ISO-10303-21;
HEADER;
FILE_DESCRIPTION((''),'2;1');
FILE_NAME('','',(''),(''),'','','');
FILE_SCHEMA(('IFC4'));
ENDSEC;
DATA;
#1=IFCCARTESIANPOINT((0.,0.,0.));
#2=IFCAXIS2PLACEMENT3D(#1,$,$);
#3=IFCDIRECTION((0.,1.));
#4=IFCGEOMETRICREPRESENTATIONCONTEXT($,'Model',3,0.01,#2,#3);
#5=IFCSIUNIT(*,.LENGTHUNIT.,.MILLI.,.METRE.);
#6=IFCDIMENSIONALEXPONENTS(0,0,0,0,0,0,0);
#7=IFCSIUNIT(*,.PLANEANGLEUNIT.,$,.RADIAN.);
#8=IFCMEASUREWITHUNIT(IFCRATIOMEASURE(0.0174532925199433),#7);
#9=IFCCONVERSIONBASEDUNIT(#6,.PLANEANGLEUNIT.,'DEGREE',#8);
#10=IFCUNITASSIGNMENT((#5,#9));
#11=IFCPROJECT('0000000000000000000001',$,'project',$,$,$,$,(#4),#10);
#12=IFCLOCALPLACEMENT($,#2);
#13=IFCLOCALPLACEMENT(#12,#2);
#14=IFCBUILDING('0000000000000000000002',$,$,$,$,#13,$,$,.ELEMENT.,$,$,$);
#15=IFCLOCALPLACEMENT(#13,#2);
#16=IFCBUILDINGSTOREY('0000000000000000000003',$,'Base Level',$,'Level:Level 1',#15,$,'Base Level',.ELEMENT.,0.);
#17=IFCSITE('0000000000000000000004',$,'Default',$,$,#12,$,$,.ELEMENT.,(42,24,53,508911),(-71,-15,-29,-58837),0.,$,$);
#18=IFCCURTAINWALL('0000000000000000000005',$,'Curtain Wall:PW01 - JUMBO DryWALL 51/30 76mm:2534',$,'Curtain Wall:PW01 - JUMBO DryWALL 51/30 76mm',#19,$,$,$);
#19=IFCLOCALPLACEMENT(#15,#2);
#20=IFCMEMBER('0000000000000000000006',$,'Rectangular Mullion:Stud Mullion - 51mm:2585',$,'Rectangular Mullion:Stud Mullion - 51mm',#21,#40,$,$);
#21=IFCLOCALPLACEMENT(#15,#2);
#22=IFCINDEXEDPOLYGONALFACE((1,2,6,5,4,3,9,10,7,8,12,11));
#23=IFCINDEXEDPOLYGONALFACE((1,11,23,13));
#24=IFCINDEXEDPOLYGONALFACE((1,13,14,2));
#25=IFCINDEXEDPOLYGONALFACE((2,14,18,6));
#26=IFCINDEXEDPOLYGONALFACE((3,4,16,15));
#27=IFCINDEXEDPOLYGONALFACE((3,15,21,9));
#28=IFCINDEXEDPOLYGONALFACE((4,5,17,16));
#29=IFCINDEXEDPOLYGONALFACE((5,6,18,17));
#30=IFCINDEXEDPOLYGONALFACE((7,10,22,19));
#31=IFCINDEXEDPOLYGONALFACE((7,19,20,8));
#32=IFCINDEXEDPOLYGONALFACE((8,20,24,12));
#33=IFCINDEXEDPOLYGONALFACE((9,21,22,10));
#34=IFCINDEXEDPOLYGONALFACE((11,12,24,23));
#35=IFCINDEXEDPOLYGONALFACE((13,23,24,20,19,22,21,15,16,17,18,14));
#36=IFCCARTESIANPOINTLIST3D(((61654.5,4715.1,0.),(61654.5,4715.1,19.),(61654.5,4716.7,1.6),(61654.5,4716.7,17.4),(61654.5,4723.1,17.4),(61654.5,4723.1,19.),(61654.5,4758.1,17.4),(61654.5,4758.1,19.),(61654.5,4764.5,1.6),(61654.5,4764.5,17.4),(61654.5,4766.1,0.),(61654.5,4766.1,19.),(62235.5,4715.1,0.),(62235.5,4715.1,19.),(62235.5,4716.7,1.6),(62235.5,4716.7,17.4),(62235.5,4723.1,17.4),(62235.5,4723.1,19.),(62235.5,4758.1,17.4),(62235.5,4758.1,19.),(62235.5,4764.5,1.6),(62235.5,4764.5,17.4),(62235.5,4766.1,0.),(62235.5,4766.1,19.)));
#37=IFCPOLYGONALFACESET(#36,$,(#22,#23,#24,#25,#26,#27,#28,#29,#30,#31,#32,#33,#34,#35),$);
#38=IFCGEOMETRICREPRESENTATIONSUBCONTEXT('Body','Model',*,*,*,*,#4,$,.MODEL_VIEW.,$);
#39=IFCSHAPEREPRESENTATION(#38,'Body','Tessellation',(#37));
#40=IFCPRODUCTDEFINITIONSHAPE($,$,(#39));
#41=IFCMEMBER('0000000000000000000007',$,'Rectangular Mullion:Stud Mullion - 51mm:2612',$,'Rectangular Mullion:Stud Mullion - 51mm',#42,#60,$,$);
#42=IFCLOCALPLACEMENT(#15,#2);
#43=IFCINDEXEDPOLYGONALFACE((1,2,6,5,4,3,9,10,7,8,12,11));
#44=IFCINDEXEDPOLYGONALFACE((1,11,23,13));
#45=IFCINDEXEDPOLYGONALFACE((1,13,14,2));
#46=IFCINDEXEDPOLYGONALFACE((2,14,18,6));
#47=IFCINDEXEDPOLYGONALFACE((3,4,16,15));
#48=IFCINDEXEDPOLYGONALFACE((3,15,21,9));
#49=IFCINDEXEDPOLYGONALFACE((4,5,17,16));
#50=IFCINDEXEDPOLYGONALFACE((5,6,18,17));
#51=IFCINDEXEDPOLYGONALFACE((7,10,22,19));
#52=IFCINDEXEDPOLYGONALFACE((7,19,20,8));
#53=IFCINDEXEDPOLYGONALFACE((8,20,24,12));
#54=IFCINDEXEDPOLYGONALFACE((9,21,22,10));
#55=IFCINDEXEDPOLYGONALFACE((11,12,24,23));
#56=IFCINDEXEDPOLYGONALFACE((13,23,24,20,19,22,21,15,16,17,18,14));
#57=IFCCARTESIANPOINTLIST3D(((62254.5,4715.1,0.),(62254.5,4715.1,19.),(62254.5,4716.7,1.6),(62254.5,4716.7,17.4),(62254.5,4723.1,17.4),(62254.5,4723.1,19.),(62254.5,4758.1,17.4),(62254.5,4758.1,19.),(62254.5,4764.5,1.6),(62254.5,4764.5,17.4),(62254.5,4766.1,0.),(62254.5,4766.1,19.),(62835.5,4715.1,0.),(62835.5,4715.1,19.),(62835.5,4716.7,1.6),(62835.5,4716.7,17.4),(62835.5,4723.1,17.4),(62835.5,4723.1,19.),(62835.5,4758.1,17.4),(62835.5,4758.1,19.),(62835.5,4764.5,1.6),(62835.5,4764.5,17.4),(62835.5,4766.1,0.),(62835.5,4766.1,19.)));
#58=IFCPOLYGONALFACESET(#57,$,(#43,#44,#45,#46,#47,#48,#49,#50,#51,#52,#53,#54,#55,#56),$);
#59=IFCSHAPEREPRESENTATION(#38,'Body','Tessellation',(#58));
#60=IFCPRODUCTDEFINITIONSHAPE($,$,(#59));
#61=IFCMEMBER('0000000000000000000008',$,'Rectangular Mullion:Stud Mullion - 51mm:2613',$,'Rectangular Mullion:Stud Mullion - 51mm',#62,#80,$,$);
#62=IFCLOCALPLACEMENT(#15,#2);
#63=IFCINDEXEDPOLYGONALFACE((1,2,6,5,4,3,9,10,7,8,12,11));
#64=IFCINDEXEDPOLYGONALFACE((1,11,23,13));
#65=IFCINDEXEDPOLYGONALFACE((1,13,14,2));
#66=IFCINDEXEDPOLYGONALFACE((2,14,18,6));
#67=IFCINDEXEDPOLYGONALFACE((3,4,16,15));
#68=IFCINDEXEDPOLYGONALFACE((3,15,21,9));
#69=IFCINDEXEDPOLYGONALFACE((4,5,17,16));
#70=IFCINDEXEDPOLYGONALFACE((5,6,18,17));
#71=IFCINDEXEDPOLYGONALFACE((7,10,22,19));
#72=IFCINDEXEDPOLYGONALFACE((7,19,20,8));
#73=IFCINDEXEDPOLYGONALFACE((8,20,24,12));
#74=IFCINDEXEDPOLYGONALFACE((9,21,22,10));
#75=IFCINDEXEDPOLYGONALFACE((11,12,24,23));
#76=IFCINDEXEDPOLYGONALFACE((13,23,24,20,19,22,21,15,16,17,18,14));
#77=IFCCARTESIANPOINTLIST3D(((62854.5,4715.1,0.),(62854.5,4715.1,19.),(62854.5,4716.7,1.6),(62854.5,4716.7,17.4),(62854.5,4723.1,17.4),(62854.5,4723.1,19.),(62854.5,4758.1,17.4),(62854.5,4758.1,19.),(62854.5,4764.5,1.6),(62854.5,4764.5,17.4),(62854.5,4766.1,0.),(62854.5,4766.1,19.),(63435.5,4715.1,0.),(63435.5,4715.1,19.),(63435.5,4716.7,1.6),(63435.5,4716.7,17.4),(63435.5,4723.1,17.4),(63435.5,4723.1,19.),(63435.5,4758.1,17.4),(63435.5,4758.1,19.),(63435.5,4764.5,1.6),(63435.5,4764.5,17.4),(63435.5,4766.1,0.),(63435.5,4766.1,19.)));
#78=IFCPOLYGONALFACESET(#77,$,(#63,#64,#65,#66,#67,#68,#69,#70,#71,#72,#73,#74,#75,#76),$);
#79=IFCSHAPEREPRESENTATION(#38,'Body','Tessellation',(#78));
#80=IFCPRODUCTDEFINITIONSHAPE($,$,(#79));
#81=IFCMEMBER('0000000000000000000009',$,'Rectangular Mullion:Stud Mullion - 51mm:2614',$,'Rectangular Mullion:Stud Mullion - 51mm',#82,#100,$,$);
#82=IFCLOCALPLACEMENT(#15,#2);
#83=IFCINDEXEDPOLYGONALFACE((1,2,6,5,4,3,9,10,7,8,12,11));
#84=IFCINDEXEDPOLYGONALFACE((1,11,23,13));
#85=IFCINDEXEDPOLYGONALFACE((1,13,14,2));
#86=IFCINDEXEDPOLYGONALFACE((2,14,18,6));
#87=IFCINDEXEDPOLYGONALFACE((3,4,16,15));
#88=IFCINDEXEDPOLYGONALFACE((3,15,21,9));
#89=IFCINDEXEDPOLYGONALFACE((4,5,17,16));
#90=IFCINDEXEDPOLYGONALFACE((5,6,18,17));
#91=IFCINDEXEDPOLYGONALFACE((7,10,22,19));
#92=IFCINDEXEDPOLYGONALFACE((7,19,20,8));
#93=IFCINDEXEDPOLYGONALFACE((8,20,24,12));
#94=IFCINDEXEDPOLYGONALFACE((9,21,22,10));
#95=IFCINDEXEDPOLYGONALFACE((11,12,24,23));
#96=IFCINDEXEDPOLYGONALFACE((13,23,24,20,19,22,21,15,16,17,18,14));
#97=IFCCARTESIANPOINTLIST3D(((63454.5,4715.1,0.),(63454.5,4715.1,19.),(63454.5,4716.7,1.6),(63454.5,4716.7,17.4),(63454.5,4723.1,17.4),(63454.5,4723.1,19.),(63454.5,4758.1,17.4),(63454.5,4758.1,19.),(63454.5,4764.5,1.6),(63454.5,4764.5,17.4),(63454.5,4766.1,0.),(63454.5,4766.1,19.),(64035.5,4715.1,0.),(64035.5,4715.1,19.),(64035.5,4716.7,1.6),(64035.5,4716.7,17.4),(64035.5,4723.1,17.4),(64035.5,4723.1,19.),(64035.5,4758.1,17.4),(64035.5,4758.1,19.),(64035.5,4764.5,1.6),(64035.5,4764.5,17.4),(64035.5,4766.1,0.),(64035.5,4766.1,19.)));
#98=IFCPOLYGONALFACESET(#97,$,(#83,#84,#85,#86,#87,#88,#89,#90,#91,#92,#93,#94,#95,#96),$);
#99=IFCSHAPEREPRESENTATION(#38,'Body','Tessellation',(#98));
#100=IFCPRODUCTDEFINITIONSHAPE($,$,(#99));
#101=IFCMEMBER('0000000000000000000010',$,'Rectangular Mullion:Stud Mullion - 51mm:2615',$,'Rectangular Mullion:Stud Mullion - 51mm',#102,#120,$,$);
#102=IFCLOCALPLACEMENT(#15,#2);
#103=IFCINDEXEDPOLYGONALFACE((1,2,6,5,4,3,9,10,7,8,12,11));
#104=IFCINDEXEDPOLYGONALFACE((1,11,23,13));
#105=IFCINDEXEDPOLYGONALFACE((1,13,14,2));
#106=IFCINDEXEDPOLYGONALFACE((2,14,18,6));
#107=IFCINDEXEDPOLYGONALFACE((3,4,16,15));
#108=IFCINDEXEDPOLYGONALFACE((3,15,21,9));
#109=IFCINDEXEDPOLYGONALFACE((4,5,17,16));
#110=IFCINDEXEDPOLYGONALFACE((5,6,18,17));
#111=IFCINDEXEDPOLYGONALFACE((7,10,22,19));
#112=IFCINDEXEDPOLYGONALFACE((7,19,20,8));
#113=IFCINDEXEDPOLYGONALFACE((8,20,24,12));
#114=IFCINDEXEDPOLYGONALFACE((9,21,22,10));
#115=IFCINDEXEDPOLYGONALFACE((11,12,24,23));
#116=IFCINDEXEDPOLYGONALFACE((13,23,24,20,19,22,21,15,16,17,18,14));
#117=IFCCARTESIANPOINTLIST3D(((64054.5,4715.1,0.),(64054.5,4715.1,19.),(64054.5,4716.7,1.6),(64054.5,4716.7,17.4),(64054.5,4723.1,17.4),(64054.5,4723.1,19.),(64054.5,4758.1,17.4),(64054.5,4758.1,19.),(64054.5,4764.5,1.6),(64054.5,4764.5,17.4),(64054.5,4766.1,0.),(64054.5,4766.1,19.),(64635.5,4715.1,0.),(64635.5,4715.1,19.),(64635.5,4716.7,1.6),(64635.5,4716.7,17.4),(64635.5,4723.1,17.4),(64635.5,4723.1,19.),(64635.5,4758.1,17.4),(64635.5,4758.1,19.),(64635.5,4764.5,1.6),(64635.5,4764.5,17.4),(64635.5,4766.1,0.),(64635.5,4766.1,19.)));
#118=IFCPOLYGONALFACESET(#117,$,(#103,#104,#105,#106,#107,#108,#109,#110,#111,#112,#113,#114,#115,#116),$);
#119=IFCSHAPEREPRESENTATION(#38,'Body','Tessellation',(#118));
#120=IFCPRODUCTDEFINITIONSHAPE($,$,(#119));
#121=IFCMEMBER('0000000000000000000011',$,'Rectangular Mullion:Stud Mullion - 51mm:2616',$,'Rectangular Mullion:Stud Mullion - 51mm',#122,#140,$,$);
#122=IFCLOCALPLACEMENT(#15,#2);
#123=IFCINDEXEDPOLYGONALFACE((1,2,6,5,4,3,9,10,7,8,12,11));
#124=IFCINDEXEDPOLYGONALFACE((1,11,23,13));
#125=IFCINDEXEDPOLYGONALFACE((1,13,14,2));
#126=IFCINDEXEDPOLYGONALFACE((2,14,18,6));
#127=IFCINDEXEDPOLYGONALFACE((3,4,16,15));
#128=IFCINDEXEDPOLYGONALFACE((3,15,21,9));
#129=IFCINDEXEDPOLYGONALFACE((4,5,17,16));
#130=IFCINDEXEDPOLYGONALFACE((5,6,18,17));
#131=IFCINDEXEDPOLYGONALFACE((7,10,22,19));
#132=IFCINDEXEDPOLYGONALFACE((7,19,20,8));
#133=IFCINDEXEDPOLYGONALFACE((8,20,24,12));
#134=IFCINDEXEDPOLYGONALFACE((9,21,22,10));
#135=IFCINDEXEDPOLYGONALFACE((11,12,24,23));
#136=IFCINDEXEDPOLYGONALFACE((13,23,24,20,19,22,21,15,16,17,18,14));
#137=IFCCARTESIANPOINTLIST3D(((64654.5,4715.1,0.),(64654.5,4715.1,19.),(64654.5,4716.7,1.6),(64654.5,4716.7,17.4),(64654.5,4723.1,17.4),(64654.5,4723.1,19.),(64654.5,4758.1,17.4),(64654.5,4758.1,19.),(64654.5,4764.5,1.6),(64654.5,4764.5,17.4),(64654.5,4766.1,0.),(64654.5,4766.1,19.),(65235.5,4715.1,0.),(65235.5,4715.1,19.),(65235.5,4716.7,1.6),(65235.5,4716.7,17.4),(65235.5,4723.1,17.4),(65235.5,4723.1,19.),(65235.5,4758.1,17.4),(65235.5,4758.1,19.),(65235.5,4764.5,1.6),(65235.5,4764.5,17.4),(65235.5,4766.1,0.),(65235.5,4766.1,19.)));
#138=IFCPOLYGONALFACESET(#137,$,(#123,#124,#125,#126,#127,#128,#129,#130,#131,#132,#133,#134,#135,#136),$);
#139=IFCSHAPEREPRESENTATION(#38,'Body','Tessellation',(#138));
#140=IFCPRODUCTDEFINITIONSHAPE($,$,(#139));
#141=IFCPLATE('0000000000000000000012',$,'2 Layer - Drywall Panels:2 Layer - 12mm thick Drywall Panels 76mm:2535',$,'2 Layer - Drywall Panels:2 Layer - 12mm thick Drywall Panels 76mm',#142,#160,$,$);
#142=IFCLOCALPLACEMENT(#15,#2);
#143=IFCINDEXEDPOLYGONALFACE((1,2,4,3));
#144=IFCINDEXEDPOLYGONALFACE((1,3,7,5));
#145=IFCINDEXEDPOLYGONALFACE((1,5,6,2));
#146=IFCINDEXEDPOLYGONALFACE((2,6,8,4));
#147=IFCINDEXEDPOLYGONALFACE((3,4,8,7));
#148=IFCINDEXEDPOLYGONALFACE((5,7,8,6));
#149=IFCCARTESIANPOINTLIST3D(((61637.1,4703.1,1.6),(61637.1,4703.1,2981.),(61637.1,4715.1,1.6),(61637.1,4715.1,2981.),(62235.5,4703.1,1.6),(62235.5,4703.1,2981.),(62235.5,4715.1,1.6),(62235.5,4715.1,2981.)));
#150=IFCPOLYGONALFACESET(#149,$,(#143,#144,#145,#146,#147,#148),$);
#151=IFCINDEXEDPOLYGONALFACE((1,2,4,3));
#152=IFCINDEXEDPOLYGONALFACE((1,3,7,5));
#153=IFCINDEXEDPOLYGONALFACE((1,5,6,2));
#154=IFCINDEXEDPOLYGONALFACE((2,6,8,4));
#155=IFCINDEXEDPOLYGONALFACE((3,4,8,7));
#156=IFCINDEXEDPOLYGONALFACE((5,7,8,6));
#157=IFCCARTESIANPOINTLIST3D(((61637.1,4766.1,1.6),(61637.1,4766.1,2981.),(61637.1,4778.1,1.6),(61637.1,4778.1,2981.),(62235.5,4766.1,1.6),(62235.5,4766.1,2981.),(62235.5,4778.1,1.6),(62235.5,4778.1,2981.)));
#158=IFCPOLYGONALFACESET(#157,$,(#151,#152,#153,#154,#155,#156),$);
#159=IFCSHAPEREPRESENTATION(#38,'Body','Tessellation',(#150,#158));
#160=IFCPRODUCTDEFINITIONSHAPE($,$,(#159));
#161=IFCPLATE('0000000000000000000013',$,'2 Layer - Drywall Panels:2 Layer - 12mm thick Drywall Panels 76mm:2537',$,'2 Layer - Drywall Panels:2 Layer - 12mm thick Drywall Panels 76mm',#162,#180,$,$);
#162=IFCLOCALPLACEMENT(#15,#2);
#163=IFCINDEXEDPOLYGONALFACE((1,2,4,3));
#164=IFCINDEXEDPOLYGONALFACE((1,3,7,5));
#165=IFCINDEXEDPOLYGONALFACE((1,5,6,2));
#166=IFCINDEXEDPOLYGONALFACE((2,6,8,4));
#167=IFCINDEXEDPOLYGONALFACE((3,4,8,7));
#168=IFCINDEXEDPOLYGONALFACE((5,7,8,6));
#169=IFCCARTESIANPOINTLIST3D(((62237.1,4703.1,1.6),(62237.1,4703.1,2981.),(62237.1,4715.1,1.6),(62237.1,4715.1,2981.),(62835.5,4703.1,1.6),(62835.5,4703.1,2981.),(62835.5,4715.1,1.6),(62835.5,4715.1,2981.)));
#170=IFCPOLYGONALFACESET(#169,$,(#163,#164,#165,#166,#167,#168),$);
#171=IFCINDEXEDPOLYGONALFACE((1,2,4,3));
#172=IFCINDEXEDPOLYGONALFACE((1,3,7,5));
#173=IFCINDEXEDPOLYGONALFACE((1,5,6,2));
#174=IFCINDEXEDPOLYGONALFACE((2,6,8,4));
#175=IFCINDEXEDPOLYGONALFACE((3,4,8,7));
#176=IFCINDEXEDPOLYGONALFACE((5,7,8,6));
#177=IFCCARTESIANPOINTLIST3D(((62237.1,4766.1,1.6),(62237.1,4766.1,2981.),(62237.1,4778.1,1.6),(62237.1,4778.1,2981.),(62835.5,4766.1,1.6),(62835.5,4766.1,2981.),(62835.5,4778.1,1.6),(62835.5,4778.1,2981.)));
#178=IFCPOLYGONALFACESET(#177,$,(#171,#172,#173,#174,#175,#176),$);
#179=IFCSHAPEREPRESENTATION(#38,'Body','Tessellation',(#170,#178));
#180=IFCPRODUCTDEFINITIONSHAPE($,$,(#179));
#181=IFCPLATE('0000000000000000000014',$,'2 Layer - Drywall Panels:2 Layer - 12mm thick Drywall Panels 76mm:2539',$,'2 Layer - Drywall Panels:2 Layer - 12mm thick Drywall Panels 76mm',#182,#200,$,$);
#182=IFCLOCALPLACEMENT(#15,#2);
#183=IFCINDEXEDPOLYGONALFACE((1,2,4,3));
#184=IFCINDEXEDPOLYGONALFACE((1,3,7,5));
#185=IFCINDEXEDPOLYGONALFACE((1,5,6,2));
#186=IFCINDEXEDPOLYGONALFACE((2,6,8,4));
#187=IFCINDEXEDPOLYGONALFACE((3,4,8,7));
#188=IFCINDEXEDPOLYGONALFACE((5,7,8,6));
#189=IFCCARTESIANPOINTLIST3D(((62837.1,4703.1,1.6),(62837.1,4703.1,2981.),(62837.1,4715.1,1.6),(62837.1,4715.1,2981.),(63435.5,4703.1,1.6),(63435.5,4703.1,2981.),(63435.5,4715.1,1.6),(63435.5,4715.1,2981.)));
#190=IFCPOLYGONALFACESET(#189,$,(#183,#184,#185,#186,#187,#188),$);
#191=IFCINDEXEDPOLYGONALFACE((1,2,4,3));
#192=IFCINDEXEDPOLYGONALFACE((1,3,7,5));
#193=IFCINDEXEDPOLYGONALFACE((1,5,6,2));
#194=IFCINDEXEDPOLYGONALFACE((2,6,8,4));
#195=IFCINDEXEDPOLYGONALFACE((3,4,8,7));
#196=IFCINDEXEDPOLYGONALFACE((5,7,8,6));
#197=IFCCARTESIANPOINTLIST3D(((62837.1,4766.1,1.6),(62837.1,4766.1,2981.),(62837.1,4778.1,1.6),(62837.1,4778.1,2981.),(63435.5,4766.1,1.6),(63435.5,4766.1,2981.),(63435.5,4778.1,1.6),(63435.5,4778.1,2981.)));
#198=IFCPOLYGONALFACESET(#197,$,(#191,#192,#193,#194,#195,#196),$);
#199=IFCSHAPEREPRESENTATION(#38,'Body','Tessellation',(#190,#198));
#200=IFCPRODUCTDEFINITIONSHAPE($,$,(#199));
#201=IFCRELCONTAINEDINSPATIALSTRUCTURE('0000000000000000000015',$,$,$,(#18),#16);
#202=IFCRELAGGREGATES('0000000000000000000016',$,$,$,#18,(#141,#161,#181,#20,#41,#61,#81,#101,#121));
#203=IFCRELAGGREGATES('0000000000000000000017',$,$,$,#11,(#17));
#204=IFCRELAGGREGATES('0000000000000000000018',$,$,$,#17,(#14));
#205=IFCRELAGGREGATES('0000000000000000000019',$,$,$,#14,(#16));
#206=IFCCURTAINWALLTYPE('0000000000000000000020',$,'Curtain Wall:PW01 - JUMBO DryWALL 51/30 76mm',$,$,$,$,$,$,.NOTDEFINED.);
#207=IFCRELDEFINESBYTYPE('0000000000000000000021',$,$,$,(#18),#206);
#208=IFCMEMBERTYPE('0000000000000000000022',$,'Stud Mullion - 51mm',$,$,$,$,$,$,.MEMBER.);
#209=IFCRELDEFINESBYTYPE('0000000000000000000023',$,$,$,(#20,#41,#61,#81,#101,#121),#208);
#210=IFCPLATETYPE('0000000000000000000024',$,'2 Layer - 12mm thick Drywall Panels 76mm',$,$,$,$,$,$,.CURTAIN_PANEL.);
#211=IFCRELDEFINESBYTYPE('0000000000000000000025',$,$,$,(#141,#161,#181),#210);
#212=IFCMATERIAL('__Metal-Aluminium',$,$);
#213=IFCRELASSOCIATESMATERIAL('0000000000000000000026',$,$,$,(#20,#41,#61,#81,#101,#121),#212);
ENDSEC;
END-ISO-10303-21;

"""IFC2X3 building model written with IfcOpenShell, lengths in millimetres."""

from ifc_helpers import new_model, entity, si_unit, converted_unit, direction, frame, frame_2d, origin, origin_2d_with_axis, place, context, subcontext, project, spatial, polyline, rectangle, outline, extrude, source, transform, mapped, material, type_object, type_shapes, element, aggregate, save


model = new_model("IFC2X3")

# Units and contexts
model_context = context("Model", 3, precision=0.01, world=origin(), true_north=direction((0.0, 1.0)))
body_context = subcontext(model_context, "Body", "Model", "MODEL_VIEW")
ifc_project = project(units=[si_unit("LENGTHUNIT", "METRE", prefix="MILLI"), converted_unit("PLANEANGLEUNIT", "DEGREE", entity("IfcRatioMeasure", 0.0174532925199433), si_unit("PLANEANGLEUNIT", "RADIAN"), dimensions=[0, 0, 0, 0, 0, 0, 0])], contexts=[model_context])

# Site, building, storey
site_placement = place(None, origin())
site = spatial("IfcSite", under=ifc_project, at=site_placement, Name="Default", CompositionType="ELEMENT", RefLatitude=(42, 24, 53, 508911), RefLongitude=(-71, -15, -29, -58837), RefElevation=0.0)
building_placement = place(site_placement, origin())
building = spatial("IfcBuilding", under=site, at=building_placement, CompositionType="ELEMENT")
storey_placement = place(building_placement, origin())
storey = spatial("IfcBuildingStorey", under=building, at=storey_placement, Name="Base Level", ObjectType="Level:Level 1", LongName="Base Level", CompositionType="ELEMENT", Elevation=0.0)

# Curtain wall, members, plates
curtain_wall_type = type_object("IfcCurtainWallType", Name="Curtain Wall:PW01 - JUMBO DryWALL 51/30 76mm", PredefinedType="NOTDEFINED")
curtain_wall_placement = place(building_placement, origin())
curtain_wall = element("IfcCurtainWall", 1, at=curtain_wall_placement, inside=storey, type_object=curtain_wall_type, Name="Curtain Wall:PW01 - JUMBO DryWALL 51/30 76mm:2534", ObjectType="Curtain Wall:PW01 - JUMBO DryWALL 51/30 76mm")
ifc_material_1 = material(Name="__Metal-Aluminium")
member_type_1 = type_object("IfcMemberType", Name="Stud Mullion - 51mm", PredefinedType="MEMBER")
shared_shape_1 = source(origin(), body_context, "Body", "SweptSolid", [
    extrude(outline(polyline([(17.5, -6.6), (25.5, -6.6), (25.5, 12.4), (-25.5, 12.4), (-25.5, -6.6), (-17.5, -6.6), (-17.5, -5.0), (-23.9, -5.0), (-23.9, 10.8), (23.9, 10.8), (23.9, -5.0), (17.5, -5.0), (17.5, -6.6)])), frame((-12.4, 0.0, -581.0), z_axis=(0.0, 0.0, 1.0), x_axis=(0.0, -1.0, 0.0)), (0.0, 0.0, 1.0), 581.0),
])
type_shapes(member_type_1, [shared_shape_1])
member_1_placement = place(building_placement, frame((61654.5, 4740.6, 0.0), z_axis=(-1.0, 0.0, 0.0), x_axis=(0.0, 0.0, -1.0)))
member_1 = element("IfcMember", 2, at=member_1_placement, type_object=member_type_1, material=ifc_material_1, Name="Rectangular Mullion:Stud Mullion - 51mm:2585", ObjectType="Rectangular Mullion:Stud Mullion - 51mm", context=body_context, shape_type="MappedRepresentation", body=[
    mapped(shared_shape_1, transform((0.0, 0.0, 0.0), scale=1.0)),
])
member_2_placement = place(building_placement, frame((62254.5, 4740.6, 0.0), z_axis=(-1.0, 0.0, 0.0), x_axis=(0.0, 0.0, -1.0)))
member_2 = element("IfcMember", 3, at=member_2_placement, type_object=member_type_1, material=ifc_material_1, Name="Rectangular Mullion:Stud Mullion - 51mm:2612", ObjectType="Rectangular Mullion:Stud Mullion - 51mm", context=body_context, shape_type="MappedRepresentation", body=[
    mapped(shared_shape_1, transform((0.0, 0.0, 0.0), scale=1.0)),
])
member_3_placement = place(building_placement, frame((62854.5, 4740.6, 0.0), z_axis=(-1.0, 0.0, 0.0), x_axis=(0.0, 0.0, -1.0)))
member_3 = element("IfcMember", 4, at=member_3_placement, type_object=member_type_1, material=ifc_material_1, Name="Rectangular Mullion:Stud Mullion - 51mm:2613", ObjectType="Rectangular Mullion:Stud Mullion - 51mm", context=body_context, shape_type="MappedRepresentation", body=[
    mapped(shared_shape_1, transform((0.0, 0.0, 0.0), scale=1.0)),
])
member_4_placement = place(building_placement, frame((63454.5, 4740.6, 0.0), z_axis=(-1.0, 0.0, 0.0), x_axis=(0.0, 0.0, -1.0)))
member_4 = element("IfcMember", 5, at=member_4_placement, type_object=member_type_1, material=ifc_material_1, Name="Rectangular Mullion:Stud Mullion - 51mm:2614", ObjectType="Rectangular Mullion:Stud Mullion - 51mm", context=body_context, shape_type="MappedRepresentation", body=[
    mapped(shared_shape_1, transform((0.0, 0.0, 0.0), scale=1.0)),
])
member_5_placement = place(building_placement, frame((64054.5, 4740.6, 0.0), z_axis=(-1.0, 0.0, 0.0), x_axis=(0.0, 0.0, -1.0)))
member_5 = element("IfcMember", 6, at=member_5_placement, type_object=member_type_1, material=ifc_material_1, Name="Rectangular Mullion:Stud Mullion - 51mm:2615", ObjectType="Rectangular Mullion:Stud Mullion - 51mm", context=body_context, shape_type="MappedRepresentation", body=[
    mapped(shared_shape_1, transform((0.0, 0.0, 0.0), scale=1.0)),
])
member_6_placement = place(building_placement, frame((64654.5, 4740.6, 0.0), z_axis=(-1.0, 0.0, 0.0), x_axis=(0.0, 0.0, -1.0)))
member_6 = element("IfcMember", 7, at=member_6_placement, type_object=member_type_1, material=ifc_material_1, Name="Rectangular Mullion:Stud Mullion - 51mm:2616", ObjectType="Rectangular Mullion:Stud Mullion - 51mm", context=body_context, shape_type="MappedRepresentation", body=[
    mapped(shared_shape_1, transform((0.0, 0.0, 0.0), scale=1.0)),
])
plate_type = type_object("IfcPlateType", Name="2 Layer - 12mm thick Drywall Panels 76mm", PredefinedType="CURTAIN_PANEL")
shared_shape_2 = source(origin(), body_context, "Body", "SweptSolid", [
    extrude(rectangle(XDim=598.4, YDim=12.0, at=origin_2d_with_axis()), frame((0.0, -31.5, 0.0), z_axis=(0.0, 0.0, 1.0), x_axis=(-1.0, 0.0, 0.0)), (0.0, 0.0, 1.0), 2979.4),
    extrude(rectangle(XDim=12.0, YDim=598.4, at=frame_2d((0.0, 0.0), x_axis=(1.0, 0.0))), frame((0.0, 31.5, 0.0), z_axis=(0.0, 0.0, 1.0), x_axis=(0.0, 1.0, 0.0)), (0.0, 0.0, 1.0), 2979.4),
])
type_shapes(plate_type, [shared_shape_2])
plate_1_placement = place(curtain_wall_placement, frame((61936.3, 4740.6, 1.6)))
plate_1 = element("IfcPlate", 8, at=plate_1_placement, type_object=plate_type, Name="2 Layer - Drywall Panels:2 Layer - 12mm thick Drywall Panels 76mm:2535", ObjectType="2 Layer - Drywall Panels:2 Layer - 12mm thick Drywall Panels 76mm", context=body_context, shape_type="MappedRepresentation", body=[
    mapped(shared_shape_2, transform((0.0, 0.0, 0.0), scale=1.0)),
])
plate_2_placement = place(curtain_wall_placement, frame((62536.3, 4740.6, 1.6)))
plate_2 = element("IfcPlate", 9, at=plate_2_placement, type_object=plate_type, Name="2 Layer - Drywall Panels:2 Layer - 12mm thick Drywall Panels 76mm:2537", ObjectType="2 Layer - Drywall Panels:2 Layer - 12mm thick Drywall Panels 76mm", context=body_context, shape_type="MappedRepresentation", body=[
    mapped(shared_shape_2, transform((0.0, 0.0, 0.0), scale=1.0)),
])
plate_3_placement = place(curtain_wall_placement, frame((63136.3, 4740.6, 1.6)))
plate_3 = element("IfcPlate", 10, at=plate_3_placement, type_object=plate_type, Name="2 Layer - Drywall Panels:2 Layer - 12mm thick Drywall Panels 76mm:2539", ObjectType="2 Layer - Drywall Panels:2 Layer - 12mm thick Drywall Panels 76mm", context=body_context, shape_type="MappedRepresentation", body=[
    mapped(shared_shape_2, transform((0.0, 0.0, 0.0), scale=1.0)),
])
aggregate(curtain_wall, [plate_1, plate_2, plate_3, member_1, member_2, member_3, member_4, member_5, member_6])

save(model, "model.ifc")
